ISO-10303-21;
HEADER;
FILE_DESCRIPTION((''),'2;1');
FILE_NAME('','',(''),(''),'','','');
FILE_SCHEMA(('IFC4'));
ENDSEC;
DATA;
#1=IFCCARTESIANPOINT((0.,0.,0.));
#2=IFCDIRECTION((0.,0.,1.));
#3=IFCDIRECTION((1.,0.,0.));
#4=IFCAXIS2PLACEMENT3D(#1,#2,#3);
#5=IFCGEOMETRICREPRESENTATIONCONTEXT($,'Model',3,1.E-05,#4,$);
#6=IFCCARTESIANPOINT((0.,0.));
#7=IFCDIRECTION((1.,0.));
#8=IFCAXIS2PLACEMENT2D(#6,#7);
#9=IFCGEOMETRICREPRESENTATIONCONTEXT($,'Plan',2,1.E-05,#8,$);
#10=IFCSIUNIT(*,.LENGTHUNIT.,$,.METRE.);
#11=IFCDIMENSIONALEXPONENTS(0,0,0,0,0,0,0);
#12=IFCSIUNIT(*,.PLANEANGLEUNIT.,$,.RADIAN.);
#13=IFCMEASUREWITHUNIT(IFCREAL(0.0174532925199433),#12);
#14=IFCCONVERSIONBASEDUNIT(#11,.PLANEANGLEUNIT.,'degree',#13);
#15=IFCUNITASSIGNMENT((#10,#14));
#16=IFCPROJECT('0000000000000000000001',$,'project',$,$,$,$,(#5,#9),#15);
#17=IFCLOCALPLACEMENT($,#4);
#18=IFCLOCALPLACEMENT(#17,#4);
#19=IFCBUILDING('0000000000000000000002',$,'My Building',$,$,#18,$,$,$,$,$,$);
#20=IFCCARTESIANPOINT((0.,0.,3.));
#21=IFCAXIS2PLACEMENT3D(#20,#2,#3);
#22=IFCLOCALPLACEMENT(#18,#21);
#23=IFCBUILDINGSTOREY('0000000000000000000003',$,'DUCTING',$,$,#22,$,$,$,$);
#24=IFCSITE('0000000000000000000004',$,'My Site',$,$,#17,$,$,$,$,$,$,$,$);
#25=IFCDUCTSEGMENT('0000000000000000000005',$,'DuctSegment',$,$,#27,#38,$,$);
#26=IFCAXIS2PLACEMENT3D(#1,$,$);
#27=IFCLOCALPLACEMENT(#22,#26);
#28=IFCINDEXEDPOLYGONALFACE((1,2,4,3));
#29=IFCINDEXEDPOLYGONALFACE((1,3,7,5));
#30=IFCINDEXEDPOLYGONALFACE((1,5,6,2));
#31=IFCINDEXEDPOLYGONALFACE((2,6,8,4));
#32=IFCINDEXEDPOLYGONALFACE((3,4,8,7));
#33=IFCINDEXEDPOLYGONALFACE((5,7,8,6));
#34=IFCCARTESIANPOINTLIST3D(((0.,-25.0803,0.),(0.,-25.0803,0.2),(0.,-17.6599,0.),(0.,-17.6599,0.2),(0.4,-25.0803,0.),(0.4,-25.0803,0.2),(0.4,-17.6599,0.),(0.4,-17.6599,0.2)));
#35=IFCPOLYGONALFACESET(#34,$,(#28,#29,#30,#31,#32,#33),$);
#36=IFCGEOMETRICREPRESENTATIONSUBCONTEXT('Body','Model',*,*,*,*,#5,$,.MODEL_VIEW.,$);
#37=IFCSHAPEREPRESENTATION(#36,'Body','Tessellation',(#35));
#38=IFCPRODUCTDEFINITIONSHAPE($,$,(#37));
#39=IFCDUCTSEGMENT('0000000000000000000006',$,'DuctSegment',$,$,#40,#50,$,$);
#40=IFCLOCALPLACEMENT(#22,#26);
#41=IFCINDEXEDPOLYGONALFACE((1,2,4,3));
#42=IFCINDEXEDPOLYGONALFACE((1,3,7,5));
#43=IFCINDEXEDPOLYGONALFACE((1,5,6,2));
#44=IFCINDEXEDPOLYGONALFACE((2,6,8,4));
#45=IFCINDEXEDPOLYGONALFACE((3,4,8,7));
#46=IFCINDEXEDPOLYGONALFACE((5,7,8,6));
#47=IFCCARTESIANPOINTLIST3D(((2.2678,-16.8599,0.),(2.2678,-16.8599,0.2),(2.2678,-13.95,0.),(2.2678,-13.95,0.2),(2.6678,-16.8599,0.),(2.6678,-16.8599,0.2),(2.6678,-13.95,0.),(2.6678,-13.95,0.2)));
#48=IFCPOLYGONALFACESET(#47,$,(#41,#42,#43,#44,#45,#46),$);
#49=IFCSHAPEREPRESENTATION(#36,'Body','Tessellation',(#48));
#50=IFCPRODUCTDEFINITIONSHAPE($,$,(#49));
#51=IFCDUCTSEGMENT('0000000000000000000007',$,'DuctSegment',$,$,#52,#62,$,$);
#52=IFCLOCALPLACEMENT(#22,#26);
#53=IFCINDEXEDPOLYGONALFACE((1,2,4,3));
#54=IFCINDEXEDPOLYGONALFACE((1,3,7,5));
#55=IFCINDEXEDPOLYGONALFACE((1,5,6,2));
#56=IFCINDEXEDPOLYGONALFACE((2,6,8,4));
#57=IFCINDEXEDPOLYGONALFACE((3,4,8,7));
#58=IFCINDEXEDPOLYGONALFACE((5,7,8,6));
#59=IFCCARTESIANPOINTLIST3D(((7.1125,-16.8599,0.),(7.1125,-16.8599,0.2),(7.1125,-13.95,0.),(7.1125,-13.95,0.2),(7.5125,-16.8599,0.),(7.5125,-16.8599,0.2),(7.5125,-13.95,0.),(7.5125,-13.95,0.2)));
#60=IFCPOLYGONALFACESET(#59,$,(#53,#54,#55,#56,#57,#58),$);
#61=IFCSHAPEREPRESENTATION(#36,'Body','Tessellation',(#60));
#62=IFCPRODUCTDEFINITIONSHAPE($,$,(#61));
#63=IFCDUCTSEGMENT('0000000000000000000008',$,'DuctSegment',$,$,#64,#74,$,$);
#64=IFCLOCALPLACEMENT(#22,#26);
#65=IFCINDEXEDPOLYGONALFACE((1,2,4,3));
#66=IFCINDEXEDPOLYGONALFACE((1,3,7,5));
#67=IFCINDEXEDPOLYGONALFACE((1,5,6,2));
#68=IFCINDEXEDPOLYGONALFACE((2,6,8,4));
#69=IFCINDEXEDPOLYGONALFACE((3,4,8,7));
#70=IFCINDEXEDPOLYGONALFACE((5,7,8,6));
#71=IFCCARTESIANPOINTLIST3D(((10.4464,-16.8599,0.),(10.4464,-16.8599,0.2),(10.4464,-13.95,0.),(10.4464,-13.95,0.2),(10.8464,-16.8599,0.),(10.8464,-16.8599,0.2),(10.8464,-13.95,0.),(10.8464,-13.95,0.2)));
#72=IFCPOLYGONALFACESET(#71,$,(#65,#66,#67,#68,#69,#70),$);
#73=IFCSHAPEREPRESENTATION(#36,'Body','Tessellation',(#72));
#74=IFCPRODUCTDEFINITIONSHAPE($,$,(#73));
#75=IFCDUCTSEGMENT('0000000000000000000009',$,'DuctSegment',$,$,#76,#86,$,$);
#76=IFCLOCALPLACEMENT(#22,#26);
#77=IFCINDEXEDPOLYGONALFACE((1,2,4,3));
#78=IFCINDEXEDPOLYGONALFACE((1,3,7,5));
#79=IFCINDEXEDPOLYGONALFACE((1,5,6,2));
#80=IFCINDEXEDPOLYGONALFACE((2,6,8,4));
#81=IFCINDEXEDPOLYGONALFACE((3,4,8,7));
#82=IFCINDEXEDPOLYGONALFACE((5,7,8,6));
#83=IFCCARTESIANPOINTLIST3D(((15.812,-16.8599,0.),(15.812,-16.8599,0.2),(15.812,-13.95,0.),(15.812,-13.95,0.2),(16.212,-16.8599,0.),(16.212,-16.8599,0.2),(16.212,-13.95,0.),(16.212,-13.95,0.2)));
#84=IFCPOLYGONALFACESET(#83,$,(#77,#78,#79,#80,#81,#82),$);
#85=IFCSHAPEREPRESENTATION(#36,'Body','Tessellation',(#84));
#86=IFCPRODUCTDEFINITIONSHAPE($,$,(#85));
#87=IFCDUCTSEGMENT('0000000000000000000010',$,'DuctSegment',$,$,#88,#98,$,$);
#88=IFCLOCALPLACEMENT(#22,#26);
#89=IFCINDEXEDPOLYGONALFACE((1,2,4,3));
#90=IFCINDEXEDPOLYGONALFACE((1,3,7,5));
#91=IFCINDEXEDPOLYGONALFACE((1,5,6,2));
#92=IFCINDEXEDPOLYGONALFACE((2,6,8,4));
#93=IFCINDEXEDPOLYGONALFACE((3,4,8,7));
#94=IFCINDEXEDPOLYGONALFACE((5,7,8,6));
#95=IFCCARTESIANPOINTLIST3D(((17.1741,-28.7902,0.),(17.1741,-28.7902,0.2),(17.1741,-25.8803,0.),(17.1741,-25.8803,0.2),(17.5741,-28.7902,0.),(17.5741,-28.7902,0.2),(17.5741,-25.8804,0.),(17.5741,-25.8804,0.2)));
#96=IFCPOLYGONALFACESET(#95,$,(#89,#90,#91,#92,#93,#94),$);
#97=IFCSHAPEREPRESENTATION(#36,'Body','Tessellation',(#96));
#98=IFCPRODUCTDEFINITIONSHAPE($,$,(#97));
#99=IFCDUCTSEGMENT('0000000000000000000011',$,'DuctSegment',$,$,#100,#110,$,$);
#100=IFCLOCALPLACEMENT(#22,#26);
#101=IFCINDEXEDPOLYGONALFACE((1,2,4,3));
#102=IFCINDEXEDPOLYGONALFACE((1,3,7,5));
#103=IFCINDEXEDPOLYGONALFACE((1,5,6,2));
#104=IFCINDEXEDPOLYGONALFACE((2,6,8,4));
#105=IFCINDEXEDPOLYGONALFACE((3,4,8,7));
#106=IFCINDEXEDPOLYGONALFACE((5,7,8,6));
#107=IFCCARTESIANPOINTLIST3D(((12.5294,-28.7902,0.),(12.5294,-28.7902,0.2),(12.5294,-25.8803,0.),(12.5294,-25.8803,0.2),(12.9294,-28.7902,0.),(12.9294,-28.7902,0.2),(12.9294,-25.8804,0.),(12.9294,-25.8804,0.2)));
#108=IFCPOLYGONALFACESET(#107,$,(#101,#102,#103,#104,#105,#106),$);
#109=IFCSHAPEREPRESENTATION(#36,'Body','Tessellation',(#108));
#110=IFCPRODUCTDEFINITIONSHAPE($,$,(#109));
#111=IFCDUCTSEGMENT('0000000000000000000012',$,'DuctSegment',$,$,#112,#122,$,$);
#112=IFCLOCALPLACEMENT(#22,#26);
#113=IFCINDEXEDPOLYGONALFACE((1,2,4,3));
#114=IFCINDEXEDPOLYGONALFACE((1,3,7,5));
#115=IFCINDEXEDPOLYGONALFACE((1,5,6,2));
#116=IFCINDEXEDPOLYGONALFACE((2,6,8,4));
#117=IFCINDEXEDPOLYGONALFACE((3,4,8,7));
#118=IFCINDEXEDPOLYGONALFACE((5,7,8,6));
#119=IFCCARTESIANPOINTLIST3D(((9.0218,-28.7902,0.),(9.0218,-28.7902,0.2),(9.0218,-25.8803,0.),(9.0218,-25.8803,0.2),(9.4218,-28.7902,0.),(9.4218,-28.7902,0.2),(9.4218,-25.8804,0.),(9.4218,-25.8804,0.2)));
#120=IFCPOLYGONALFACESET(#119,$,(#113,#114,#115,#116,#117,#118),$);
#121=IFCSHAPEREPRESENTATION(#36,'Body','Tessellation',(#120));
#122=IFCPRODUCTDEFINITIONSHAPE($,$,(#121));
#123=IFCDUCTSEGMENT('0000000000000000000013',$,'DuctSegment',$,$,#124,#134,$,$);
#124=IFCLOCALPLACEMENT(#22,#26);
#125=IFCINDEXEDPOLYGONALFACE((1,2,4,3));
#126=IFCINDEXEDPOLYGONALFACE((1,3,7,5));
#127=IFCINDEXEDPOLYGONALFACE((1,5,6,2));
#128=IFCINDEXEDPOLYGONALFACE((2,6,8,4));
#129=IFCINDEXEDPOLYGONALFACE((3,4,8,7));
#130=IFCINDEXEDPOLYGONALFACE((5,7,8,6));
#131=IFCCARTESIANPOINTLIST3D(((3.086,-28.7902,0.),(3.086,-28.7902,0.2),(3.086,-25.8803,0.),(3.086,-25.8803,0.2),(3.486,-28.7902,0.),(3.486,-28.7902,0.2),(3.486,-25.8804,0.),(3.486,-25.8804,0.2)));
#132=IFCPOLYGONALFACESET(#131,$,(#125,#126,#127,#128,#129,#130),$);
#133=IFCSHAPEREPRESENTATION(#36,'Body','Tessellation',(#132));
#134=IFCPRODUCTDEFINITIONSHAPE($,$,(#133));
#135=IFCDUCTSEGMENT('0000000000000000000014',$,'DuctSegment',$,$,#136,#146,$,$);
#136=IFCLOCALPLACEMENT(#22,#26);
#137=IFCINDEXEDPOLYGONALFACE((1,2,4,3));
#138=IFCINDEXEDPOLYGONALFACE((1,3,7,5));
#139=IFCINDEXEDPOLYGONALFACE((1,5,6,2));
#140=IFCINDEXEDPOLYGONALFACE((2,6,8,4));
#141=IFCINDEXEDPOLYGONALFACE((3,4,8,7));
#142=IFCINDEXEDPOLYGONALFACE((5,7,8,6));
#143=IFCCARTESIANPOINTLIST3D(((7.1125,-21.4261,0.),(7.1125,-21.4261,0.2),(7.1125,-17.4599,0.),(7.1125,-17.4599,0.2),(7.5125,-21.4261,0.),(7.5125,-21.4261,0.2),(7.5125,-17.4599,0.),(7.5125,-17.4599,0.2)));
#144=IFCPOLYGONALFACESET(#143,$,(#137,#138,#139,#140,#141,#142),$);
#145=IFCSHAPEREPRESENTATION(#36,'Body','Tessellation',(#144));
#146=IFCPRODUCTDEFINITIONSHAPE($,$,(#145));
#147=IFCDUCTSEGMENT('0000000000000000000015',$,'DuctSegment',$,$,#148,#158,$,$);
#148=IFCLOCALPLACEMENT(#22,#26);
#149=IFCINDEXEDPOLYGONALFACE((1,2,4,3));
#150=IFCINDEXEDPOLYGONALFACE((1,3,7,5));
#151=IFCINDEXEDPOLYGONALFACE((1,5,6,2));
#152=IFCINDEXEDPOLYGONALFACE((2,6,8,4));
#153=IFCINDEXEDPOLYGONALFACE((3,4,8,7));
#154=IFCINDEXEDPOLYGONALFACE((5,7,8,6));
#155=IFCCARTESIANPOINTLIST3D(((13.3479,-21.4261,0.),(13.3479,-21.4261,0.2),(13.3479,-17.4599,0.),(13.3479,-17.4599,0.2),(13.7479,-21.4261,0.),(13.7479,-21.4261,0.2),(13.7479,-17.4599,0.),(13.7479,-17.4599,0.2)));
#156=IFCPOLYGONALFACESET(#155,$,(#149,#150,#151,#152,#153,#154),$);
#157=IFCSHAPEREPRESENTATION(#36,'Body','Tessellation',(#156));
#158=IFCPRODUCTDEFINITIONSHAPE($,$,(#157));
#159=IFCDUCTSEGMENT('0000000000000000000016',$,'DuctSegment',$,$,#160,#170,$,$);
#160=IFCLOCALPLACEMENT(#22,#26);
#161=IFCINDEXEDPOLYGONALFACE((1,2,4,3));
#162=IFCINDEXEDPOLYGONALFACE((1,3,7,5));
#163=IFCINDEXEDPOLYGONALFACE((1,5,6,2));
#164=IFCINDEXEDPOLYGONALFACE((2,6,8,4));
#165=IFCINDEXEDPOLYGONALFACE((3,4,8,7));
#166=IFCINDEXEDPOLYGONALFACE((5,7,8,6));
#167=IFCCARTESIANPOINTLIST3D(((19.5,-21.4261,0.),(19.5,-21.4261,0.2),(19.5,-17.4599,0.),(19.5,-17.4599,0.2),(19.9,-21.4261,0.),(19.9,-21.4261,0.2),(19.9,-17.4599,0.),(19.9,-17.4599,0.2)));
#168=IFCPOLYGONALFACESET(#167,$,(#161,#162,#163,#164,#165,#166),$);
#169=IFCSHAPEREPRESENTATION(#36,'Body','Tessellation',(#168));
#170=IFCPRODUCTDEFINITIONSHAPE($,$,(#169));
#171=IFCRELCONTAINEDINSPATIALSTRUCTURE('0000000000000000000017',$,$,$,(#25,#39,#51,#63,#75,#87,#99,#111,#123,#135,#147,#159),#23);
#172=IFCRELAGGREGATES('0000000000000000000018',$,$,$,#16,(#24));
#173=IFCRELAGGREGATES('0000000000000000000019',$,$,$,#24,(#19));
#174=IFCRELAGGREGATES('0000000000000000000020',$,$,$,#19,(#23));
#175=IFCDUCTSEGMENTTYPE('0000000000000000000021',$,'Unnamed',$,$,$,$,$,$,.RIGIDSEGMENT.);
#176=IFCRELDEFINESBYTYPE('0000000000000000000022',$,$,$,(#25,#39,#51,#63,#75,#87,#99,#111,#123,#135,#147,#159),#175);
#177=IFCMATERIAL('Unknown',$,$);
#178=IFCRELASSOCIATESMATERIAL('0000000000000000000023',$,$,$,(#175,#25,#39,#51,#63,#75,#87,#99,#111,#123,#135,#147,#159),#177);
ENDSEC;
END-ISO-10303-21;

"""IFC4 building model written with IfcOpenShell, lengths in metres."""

from ifc_helpers import new_model, entity, si_unit, converted_unit, frame, origin_with_axes, origin_2d_with_axis, place, context, subcontext, project, spatial, rectangle, extrude, material, material_profile, profile_set, profile_usage, type_object, element, save


model = new_model("IFC4")

# Units and contexts
model_context = context("Model", 3, precision=1e-05, world=origin_with_axes())
plan_context = context("Plan", 2, precision=1e-05, world=origin_2d_with_axis())
body_context = subcontext(model_context, "Body", "Model", "MODEL_VIEW")
ifc_project = project(units=[si_unit("LENGTHUNIT", "METRE"), converted_unit("PLANEANGLEUNIT", "degree", entity("IfcReal", 0.0174532925199433), si_unit("PLANEANGLEUNIT", "RADIAN"), dimensions=[0, 0, 0, 0, 0, 0, 0])], contexts=[model_context, plan_context])

# Site, building, storey
site_placement = place(None, origin_with_axes())
site = spatial("IfcSite", under=ifc_project, at=site_placement, Name="My Site")
building_placement = place(site_placement, origin_with_axes())
building = spatial("IfcBuilding", under=site, at=building_placement, Name="My Building")
storey_placement = place(building_placement, frame((0.0, 0.0, 3.0), z_axis=(0.0, 0.0, 1.0), x_axis=(1.0, 0.0, 0.0)))
storey = spatial("IfcBuildingStorey", under=building, at=storey_placement, Name="DUCTING")

# Duct segments
ifc_material = material(Name="Unknown")
ifc_material_profile_1 = material_profile(ifc_material, rectangle(XDim=0.4, YDim=0.2))
ifc_profile_set_1 = profile_set([ifc_material_profile_1])
ifc_profile_usage_1 = profile_usage(ifc_profile_set_1, cardinal=5)
duct_segment_type = type_object("IfcDuctSegmentType", Name="Unnamed", PredefinedType="RIGIDSEGMENT", material=ifc_profile_set_1)
duct_segment_1_placement = place(storey_placement, frame((0.2, -17.6599, 0.1), z_axis=(0.0, -1.0, 0.0), x_axis=(1.0, 0.0, 0.0)))
element("IfcDuctSegment", 1, at=duct_segment_1_placement, inside=storey, type_object=duct_segment_type, material=ifc_profile_usage_1, Name="DuctSegment", context=body_context, shape_type="SweptSolid", body=[
    extrude(rectangle(XDim=0.4, YDim=0.2), origin_with_axes(), (0.0, 0.0, 1.0), 7.4205),
])
ifc_profile_usage_2 = profile_usage(ifc_profile_set_1, cardinal=5)
duct_segment_2_placement = place(storey_placement, frame((2.4678, -13.95, 0.1), z_axis=(0.0, -1.0, 0.0), x_axis=(1.0, 0.0, 0.0)))
element("IfcDuctSegment", 2, at=duct_segment_2_placement, inside=storey, type_object=duct_segment_type, material=ifc_profile_usage_2, Name="DuctSegment", context=body_context, shape_type="SweptSolid", body=[
    extrude(rectangle(XDim=0.4, YDim=0.2), origin_with_axes(), (0.0, 0.0, 1.0), 2.9099),
])
ifc_profile_usage_3 = profile_usage(ifc_profile_set_1, cardinal=5)
duct_segment_3_placement = place(storey_placement, frame((7.3125, -13.95, 0.1), z_axis=(0.0, -1.0, 0.0), x_axis=(1.0, 0.0, 0.0)))
element("IfcDuctSegment", 3, at=duct_segment_3_placement, inside=storey, type_object=duct_segment_type, material=ifc_profile_usage_3, Name="DuctSegment", context=body_context, shape_type="SweptSolid", body=[
    extrude(rectangle(XDim=0.4, YDim=0.2), origin_with_axes(), (0.0, 0.0, 1.0), 2.9099),
])
ifc_profile_usage_4 = profile_usage(ifc_profile_set_1, cardinal=5)
duct_segment_4_placement = place(storey_placement, frame((10.6464, -13.95, 0.1), z_axis=(0.0, -1.0, 0.0), x_axis=(1.0, 0.0, 0.0)))
element("IfcDuctSegment", 4, at=duct_segment_4_placement, inside=storey, type_object=duct_segment_type, material=ifc_profile_usage_4, Name="DuctSegment", context=body_context, shape_type="SweptSolid", body=[
    extrude(rectangle(XDim=0.4, YDim=0.2), origin_with_axes(), (0.0, 0.0, 1.0), 2.9099),
])
ifc_profile_usage_5 = profile_usage(ifc_profile_set_1, cardinal=5)
duct_segment_5_placement = place(storey_placement, frame((16.012, -13.95, 0.1), z_axis=(0.0, -1.0, 0.0), x_axis=(1.0, 0.0, 0.0)))
element("IfcDuctSegment", 5, at=duct_segment_5_placement, inside=storey, type_object=duct_segment_type, material=ifc_profile_usage_5, Name="DuctSegment", context=body_context, shape_type="SweptSolid", body=[
    extrude(rectangle(XDim=0.4, YDim=0.2), origin_with_axes(), (0.0, 0.0, 1.0), 2.9099),
])
ifc_profile_usage_6 = profile_usage(ifc_profile_set_1, cardinal=5)
duct_segment_6_placement = place(storey_placement, frame((17.3741, -28.7902, 0.1), z_axis=(0.000001, 1.0, 0.0), x_axis=(-1.0, 0.000001, 0.0)))
element("IfcDuctSegment", 6, at=duct_segment_6_placement, inside=storey, type_object=duct_segment_type, material=ifc_profile_usage_6, Name="DuctSegment", context=body_context, shape_type="SweptSolid", body=[
    extrude(rectangle(XDim=0.4, YDim=0.2), origin_with_axes(), (0.0, 0.0, 1.0), 2.9099),
])
ifc_profile_usage_7 = profile_usage(ifc_profile_set_1, cardinal=5)
duct_segment_7_placement = place(storey_placement, frame((12.7294, -28.7902, 0.1), z_axis=(0.000001, 1.0, 0.0), x_axis=(-1.0, 0.000001, 0.0)))
element("IfcDuctSegment", 7, at=duct_segment_7_placement, inside=storey, type_object=duct_segment_type, material=ifc_profile_usage_7, Name="DuctSegment", context=body_context, shape_type="SweptSolid", body=[
    extrude(rectangle(XDim=0.4, YDim=0.2), origin_with_axes(), (0.0, 0.0, 1.0), 2.9099),
])
ifc_profile_usage_8 = profile_usage(ifc_profile_set_1, cardinal=5)
duct_segment_8_placement = place(storey_placement, frame((9.2218, -28.7902, 0.1), z_axis=(0.000001, 1.0, 0.0), x_axis=(-1.0, 0.000001, 0.0)))
element("IfcDuctSegment", 8, at=duct_segment_8_placement, inside=storey, type_object=duct_segment_type, material=ifc_profile_usage_8, Name="DuctSegment", context=body_context, shape_type="SweptSolid", body=[
    extrude(rectangle(XDim=0.4, YDim=0.2), origin_with_axes(), (0.0, 0.0, 1.0), 2.9099),
])
ifc_profile_usage_9 = profile_usage(ifc_profile_set_1, cardinal=5)
duct_segment_9_placement = place(storey_placement, frame((3.286, -28.7902, 0.1), z_axis=(0.000001, 1.0, 0.0), x_axis=(-1.0, 0.000001, 0.0)))
element("IfcDuctSegment", 9, at=duct_segment_9_placement, inside=storey, type_object=duct_segment_type, material=ifc_profile_usage_9, Name="DuctSegment", context=body_context, shape_type="SweptSolid", body=[
    extrude(rectangle(XDim=0.4, YDim=0.2), origin_with_axes(), (0.0, 0.0, 1.0), 2.9099),
])
ifc_profile_usage_10 = profile_usage(ifc_profile_set_1, cardinal=5)
duct_segment_10_placement = place(storey_placement, frame((7.3125, -21.4261, 0.1), z_axis=(0.000001, 1.0, 0.0), x_axis=(-1.0, 0.000001, 0.0)))
element("IfcDuctSegment", 10, at=duct_segment_10_placement, inside=storey, type_object=duct_segment_type, material=ifc_profile_usage_10, Name="DuctSegment", context=body_context, shape_type="SweptSolid", body=[
    extrude(rectangle(XDim=0.4, YDim=0.2), origin_with_axes(), (0.0, 0.0, 1.0), 3.9662),
])
ifc_profile_usage_11 = profile_usage(ifc_profile_set_1, cardinal=5)
duct_segment_11_placement = place(storey_placement, frame((13.5479, -21.4261, 0.1), z_axis=(0.000001, 1.0, 0.0), x_axis=(-1.0, 0.000001, 0.0)))
element("IfcDuctSegment", 11, at=duct_segment_11_placement, inside=storey, type_object=duct_segment_type, material=ifc_profile_usage_11, Name="DuctSegment", context=body_context, shape_type="SweptSolid", body=[
    extrude(rectangle(XDim=0.4, YDim=0.2), origin_with_axes(), (0.0, 0.0, 1.0), 3.9662),
])
ifc_profile_usage_12 = profile_usage(ifc_profile_set_1, cardinal=5)
duct_segment_12_placement = place(storey_placement, frame((19.7, -21.4261, 0.1), z_axis=(0.000001, 1.0, 0.0), x_axis=(-1.0, 0.000001, 0.0)))
element("IfcDuctSegment", 12, at=duct_segment_12_placement, inside=storey, type_object=duct_segment_type, material=ifc_profile_usage_12, Name="DuctSegment", context=body_context, shape_type="SweptSolid", body=[
    extrude(rectangle(XDim=0.4, YDim=0.2), origin_with_axes(), (0.0, 0.0, 1.0), 3.9662),
])

save(model, "model.ifc")
